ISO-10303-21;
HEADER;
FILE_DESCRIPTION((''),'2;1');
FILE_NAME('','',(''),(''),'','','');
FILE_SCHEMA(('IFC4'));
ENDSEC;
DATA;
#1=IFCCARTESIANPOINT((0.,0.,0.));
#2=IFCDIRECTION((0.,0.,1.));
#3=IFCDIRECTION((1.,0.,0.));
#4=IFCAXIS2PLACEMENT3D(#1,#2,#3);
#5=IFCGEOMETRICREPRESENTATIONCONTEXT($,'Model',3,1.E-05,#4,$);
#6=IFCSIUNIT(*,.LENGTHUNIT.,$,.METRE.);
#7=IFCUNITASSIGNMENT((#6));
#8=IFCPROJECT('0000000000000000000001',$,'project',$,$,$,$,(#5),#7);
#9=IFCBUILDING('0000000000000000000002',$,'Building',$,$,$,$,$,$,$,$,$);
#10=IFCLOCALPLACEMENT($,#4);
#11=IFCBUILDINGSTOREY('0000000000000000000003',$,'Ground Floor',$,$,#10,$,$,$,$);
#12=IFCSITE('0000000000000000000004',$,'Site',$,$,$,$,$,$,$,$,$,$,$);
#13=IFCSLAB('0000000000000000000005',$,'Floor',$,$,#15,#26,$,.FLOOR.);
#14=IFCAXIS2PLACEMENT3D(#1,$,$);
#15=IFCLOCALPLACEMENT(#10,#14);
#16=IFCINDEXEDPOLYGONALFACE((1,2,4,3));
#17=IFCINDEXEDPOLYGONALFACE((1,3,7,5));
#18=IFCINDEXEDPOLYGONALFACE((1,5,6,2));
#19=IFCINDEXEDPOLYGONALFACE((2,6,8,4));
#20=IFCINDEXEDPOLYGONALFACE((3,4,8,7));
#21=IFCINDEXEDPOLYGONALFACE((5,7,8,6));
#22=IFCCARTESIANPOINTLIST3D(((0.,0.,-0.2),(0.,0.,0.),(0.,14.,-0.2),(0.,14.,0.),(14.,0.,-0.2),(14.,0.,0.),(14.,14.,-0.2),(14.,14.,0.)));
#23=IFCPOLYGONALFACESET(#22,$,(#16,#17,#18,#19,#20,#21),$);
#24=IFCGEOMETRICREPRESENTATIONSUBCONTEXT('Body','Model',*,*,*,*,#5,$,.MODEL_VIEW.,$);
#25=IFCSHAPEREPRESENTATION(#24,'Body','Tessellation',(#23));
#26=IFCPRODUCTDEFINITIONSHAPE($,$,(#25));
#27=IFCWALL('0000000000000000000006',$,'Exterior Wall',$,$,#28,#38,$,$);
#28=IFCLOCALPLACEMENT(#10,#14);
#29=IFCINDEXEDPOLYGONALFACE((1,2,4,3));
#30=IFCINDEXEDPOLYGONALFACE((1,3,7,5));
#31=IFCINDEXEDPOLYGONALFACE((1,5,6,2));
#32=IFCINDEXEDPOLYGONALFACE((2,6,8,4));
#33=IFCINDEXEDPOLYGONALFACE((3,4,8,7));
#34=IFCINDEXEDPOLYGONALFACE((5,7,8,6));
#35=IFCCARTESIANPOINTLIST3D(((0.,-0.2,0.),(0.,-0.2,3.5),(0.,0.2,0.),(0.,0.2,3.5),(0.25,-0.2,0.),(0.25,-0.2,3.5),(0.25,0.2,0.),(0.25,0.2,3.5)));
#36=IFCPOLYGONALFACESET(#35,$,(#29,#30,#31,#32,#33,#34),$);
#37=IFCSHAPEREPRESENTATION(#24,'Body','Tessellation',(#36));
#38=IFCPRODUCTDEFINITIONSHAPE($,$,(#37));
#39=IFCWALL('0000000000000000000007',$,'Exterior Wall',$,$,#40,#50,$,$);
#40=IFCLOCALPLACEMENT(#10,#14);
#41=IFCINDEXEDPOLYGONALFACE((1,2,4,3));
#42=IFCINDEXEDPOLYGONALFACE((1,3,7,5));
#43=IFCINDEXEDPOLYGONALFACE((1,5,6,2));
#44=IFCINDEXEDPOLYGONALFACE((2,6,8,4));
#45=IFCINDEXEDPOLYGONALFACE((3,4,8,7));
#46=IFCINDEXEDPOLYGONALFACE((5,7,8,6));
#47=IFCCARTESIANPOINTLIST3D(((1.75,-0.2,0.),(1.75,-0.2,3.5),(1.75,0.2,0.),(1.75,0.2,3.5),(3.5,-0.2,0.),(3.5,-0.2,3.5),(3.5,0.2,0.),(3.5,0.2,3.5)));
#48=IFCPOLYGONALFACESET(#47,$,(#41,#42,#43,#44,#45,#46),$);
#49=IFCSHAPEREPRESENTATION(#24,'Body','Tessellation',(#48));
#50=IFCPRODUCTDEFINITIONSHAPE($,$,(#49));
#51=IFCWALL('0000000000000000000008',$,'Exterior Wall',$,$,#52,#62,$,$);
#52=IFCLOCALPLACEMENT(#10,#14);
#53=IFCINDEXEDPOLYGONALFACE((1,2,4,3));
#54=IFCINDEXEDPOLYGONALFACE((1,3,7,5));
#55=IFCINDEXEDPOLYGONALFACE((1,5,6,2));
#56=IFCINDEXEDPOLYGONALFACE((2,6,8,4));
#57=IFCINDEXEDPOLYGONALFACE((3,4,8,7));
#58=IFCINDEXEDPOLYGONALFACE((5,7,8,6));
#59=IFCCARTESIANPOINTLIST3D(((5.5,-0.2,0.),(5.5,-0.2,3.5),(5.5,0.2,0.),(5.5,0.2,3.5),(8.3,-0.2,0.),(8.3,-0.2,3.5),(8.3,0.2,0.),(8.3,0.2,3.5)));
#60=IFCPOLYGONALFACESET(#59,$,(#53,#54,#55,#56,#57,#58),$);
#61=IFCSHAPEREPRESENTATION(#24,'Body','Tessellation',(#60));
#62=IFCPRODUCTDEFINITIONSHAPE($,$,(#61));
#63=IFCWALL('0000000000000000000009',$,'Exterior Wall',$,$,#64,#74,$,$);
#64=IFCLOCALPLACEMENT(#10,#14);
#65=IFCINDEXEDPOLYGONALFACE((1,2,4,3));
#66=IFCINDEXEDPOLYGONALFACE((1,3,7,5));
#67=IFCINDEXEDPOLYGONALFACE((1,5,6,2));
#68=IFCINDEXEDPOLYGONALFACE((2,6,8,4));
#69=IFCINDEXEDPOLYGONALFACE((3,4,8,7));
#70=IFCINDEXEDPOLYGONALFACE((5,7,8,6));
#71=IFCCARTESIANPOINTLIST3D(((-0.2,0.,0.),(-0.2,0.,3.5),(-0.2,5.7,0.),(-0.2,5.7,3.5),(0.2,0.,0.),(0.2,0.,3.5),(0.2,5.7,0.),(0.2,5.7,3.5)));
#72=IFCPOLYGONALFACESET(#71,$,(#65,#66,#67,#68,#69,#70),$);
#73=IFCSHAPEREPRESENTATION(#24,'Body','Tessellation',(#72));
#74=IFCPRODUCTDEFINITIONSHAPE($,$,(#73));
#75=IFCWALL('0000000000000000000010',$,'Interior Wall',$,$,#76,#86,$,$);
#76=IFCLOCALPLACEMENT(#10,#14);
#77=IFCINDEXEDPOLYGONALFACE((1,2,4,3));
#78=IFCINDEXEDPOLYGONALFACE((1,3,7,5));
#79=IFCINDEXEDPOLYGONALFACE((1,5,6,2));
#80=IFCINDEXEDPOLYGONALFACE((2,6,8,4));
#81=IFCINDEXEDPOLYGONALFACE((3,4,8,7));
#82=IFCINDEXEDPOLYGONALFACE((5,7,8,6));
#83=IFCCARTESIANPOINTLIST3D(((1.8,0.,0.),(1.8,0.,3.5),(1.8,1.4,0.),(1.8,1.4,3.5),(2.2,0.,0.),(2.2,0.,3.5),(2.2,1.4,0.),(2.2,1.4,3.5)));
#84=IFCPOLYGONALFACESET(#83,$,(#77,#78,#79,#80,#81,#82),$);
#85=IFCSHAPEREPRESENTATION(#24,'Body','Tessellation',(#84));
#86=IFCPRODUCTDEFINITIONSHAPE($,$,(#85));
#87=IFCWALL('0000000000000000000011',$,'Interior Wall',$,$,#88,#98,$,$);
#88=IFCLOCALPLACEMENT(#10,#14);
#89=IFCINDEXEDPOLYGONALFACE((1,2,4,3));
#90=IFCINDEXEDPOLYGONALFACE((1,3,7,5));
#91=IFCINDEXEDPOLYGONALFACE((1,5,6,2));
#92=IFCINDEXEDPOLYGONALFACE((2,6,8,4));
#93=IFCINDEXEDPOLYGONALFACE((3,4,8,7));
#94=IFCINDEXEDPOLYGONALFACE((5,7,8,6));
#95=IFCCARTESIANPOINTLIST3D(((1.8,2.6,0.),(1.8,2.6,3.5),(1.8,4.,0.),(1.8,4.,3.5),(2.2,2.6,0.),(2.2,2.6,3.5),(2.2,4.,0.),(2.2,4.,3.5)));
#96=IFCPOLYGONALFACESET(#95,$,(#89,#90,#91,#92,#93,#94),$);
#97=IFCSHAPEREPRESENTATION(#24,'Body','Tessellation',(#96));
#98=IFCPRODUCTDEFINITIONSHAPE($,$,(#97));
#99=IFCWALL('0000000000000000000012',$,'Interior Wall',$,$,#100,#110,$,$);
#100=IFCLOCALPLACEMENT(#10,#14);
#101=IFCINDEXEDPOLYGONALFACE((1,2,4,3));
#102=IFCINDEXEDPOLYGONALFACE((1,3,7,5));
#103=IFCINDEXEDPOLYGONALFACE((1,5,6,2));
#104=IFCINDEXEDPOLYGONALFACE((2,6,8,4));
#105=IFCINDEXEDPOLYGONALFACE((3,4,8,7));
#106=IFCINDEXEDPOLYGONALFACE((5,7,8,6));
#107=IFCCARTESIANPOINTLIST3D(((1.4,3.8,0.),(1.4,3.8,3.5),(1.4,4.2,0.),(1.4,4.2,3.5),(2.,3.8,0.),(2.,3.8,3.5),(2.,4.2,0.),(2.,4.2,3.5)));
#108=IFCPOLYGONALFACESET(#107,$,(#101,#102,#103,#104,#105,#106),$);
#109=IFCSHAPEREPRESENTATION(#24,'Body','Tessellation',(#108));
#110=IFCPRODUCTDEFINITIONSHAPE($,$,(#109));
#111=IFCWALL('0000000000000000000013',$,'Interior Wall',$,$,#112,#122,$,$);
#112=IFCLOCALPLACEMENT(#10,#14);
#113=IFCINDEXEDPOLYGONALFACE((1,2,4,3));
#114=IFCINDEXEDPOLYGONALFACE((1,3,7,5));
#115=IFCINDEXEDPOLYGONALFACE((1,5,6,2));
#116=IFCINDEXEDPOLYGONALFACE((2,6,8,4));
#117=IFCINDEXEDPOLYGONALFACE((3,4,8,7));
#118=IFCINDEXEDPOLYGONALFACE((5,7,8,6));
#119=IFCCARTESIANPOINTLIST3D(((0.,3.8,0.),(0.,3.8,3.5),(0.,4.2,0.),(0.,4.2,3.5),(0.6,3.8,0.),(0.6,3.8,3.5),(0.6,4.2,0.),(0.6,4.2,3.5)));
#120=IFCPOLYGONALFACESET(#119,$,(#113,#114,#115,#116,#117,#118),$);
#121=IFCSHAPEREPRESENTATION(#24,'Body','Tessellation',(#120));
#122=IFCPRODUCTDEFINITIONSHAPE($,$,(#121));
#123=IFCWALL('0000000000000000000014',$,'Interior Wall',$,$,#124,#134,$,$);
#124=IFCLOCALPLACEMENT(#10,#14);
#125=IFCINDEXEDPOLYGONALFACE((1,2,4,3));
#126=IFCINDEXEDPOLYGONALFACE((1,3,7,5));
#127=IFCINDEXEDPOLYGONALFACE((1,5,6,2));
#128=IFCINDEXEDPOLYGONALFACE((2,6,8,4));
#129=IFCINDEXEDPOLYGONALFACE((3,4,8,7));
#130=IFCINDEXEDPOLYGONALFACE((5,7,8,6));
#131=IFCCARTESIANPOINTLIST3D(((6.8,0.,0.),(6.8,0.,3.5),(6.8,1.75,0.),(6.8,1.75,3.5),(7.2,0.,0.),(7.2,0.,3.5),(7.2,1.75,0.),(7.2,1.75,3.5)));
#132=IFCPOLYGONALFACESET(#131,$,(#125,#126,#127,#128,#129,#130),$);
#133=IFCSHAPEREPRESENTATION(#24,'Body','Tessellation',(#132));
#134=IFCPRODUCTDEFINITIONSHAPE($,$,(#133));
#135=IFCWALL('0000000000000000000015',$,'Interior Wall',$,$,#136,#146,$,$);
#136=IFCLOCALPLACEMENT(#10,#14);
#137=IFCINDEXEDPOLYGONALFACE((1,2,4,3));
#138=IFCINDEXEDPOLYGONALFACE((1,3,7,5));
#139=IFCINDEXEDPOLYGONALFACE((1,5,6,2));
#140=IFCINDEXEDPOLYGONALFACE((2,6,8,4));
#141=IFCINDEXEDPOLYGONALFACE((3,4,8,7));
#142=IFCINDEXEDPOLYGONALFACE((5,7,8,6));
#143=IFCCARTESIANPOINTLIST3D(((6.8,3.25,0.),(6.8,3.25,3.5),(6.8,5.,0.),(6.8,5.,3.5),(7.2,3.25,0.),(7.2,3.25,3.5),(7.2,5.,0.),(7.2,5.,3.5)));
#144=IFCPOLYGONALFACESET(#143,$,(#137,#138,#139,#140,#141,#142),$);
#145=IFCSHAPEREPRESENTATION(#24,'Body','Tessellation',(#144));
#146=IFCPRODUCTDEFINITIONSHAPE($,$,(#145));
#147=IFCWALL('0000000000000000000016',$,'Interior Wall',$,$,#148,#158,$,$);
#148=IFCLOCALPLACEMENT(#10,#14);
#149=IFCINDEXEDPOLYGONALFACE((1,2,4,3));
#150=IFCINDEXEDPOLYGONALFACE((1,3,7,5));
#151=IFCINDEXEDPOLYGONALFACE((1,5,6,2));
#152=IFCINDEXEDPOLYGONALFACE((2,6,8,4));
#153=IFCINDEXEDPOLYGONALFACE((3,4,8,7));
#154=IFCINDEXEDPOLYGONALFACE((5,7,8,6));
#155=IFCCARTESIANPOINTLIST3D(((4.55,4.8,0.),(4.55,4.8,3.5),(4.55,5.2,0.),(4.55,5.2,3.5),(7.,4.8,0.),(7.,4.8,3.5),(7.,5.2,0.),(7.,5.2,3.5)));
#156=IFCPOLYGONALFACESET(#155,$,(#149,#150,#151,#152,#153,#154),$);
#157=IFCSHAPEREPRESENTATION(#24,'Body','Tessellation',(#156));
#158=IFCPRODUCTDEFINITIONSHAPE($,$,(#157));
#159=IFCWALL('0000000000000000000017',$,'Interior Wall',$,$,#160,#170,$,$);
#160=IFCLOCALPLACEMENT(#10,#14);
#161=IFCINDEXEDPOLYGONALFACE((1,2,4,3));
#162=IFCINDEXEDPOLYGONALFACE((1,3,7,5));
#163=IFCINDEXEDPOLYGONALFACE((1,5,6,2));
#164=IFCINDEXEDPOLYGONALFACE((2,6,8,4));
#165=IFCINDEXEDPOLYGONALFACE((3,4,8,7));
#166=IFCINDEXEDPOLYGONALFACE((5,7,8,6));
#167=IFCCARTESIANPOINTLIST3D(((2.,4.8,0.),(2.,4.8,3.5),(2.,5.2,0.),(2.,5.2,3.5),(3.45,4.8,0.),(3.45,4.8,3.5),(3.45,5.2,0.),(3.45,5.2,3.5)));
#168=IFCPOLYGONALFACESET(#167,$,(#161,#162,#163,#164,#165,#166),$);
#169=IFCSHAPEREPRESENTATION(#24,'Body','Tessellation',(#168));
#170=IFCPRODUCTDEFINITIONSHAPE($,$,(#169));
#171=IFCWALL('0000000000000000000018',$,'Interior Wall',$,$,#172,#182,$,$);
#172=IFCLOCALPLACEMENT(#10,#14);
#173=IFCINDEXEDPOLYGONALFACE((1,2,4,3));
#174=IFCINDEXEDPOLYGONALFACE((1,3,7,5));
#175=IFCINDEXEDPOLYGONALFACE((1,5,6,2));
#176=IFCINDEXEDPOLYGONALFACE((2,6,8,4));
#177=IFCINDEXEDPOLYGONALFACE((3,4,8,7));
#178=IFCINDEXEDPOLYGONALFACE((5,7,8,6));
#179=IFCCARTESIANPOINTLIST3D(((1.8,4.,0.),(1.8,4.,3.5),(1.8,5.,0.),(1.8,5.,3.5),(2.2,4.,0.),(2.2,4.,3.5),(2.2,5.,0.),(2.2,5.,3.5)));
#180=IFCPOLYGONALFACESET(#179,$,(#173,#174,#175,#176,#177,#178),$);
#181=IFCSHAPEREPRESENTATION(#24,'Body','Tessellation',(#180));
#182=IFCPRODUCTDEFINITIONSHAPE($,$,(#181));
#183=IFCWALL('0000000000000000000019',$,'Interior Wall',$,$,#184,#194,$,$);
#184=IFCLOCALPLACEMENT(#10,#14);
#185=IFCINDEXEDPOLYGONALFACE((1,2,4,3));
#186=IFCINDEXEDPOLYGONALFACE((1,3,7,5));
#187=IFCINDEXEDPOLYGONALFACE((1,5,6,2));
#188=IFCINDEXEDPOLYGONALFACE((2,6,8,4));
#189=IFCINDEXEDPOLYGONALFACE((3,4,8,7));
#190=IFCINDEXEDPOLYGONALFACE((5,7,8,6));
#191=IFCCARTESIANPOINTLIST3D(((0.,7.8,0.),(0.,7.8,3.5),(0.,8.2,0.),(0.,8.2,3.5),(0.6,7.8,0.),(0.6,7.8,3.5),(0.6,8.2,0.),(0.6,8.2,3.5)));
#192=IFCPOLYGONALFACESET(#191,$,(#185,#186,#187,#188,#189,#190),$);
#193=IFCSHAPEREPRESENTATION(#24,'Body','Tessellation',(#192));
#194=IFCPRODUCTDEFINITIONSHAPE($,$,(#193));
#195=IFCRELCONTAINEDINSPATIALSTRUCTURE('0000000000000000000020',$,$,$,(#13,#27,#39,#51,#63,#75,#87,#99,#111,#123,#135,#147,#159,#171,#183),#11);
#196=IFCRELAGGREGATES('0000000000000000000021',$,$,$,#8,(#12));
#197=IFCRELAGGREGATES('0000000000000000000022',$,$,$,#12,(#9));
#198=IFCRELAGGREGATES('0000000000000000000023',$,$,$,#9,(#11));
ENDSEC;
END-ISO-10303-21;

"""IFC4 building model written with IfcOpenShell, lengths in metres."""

from ifc_helpers import new_model, si_unit, frame, origin_with_axes, place, context, subcontext, project, spatial, indexed_curve, outline, extrude, element, save


model = new_model("IFC4")

# Units and contexts
model_context = context("Model", 3, precision=1e-05, world=origin_with_axes())
body_context = subcontext(model_context, "Body", "Model", "MODEL_VIEW")
ifc_project = project(units=[si_unit("LENGTHUNIT", "METRE")], contexts=[model_context])

# Site, building, storey
site = spatial("IfcSite", under=ifc_project, Name="Site")
building = spatial("IfcBuilding", under=site, Name="Building")
storey_placement = place(None, origin_with_axes())
storey = spatial("IfcBuildingStorey", under=building, at=storey_placement, Name="Ground Floor")

# Slab
slab_placement = place(storey_placement, frame((0.0, 0.0, -0.2), z_axis=(0.0, 0.0, 1.0), x_axis=(1.0, 0.0, 0.0)))
element("IfcSlab", 1, at=slab_placement, inside=storey, Name="Floor", PredefinedType="FLOOR", context=body_context, shape_type="SweptSolid", body=[
    extrude(outline(indexed_curve([(0.0, 0.0), (14.0, 0.0), (14.0, 14.0), (0.0, 14.0)])), None, (0.0, 0.0, 1.0), 0.2),
])

# Walls
wall_1_placement = place(storey_placement, origin_with_axes())
element("IfcWall", 2, at=wall_1_placement, inside=storey, Name="Exterior Wall", context=body_context, shape_type="SweptSolid", body=[
    extrude(outline(indexed_curve([(0.0, 0.0), (0.0, 0.4), (0.25, 0.4), (0.25, 0.0), (0.0, 0.0)], self_intersect=False)), frame((0.0, -0.2, 0.0), z_axis=(0.0, 0.0, 1.0), x_axis=(1.0, 0.0, 0.0)), (0.0, 0.0, 1.0), 3.5),
])
wall_2_placement = place(storey_placement, frame((1.75, 0.0, 0.0), z_axis=(0.0, 0.0, 1.0), x_axis=(1.0, 0.0, 0.0)))
element("IfcWall", 3, at=wall_2_placement, inside=storey, Name="Exterior Wall", context=body_context, shape_type="SweptSolid", body=[
    extrude(outline(indexed_curve([(0.0, 0.0), (0.0, 0.4), (1.75, 0.4), (1.75, 0.0), (0.0, 0.0)], self_intersect=False)), frame((0.0, -0.2, 0.0), z_axis=(0.0, 0.0, 1.0), x_axis=(1.0, 0.0, 0.0)), (0.0, 0.0, 1.0), 3.5),
])
wall_3_placement = place(storey_placement, frame((5.5, 0.0, 0.0), z_axis=(0.0, 0.0, 1.0), x_axis=(1.0, 0.0, 0.0)))
element("IfcWall", 4, at=wall_3_placement, inside=storey, Name="Exterior Wall", context=body_context, shape_type="SweptSolid", body=[
    extrude(outline(indexed_curve([(0.0, 0.0), (0.0, 0.4), (2.8, 0.4), (2.8, 0.0), (0.0, 0.0)], self_intersect=False)), frame((0.0, -0.2, 0.0), z_axis=(0.0, 0.0, 1.0), x_axis=(1.0, 0.0, 0.0)), (0.0, 0.0, 1.0), 3.5),
])
wall_4_placement = place(storey_placement, frame((0.0, 5.7, 0.0), z_axis=(0.0, 0.0, 1.0), x_axis=(0.0, -1.0, 0.0)))
element("IfcWall", 5, at=wall_4_placement, inside=storey, Name="Exterior Wall", context=body_context, shape_type="SweptSolid", body=[
    extrude(outline(indexed_curve([(0.0, 0.0), (0.0, 0.4), (5.7, 0.4), (5.7, 0.0), (0.0, 0.0)], self_intersect=False)), frame((0.0, -0.2, 0.0), z_axis=(0.0, 0.0, 1.0), x_axis=(1.0, 0.0, 0.0)), (0.0, 0.0, 1.0), 3.5),
])
for number, where, z_axis, x_axis, name in (
    (6, (2.0, 0.0, 0.0), (0.0, 0.0, 1.0), (0.0, 1.0, 0.0), "Interior Wall"),
    (7, (2.0, 2.6, 0.0), (0.0, 0.0, 1.0), (0.0, 1.0, 0.0), "Interior Wall"),
):
    element("IfcWall", number, at=place(storey_placement, frame(where, z_axis=z_axis, x_axis=x_axis)), inside=storey, Name=name, context=body_context, shape_type="SweptSolid", body=[
        extrude(outline(indexed_curve([(0.0, 0.0), (0.0, 0.4), (1.4, 0.4), (1.4, 0.0), (0.0, 0.0)], self_intersect=False)), frame((0.0, -0.2, 0.0), z_axis=(0.0, 0.0, 1.0), x_axis=(1.0, 0.0, 0.0)), (0.0, 0.0, 1.0), 3.5),
    ])
for number, where, z_axis, x_axis, name in (
    (8, (2.0, 4.0, 0.0), (0.0, 0.0, 1.0), (-1.0, 0.0, 0.0), "Interior Wall"),
    (9, (0.6, 4.0, 0.0), (0.0, 0.0, 1.0), (-1.0, 0.0, 0.0), "Interior Wall"),
):
    element("IfcWall", number, at=place(storey_placement, frame(where, z_axis=z_axis, x_axis=x_axis)), inside=storey, Name=name, context=body_context, shape_type="SweptSolid", body=[
        extrude(outline(indexed_curve([(0.0, 0.0), (0.0, 0.4), (0.6, 0.4), (0.6, 0.0), (0.0, 0.0)], self_intersect=False)), frame((0.0, -0.2, 0.0), z_axis=(0.0, 0.0, 1.0), x_axis=(1.0, 0.0, 0.0)), (0.0, 0.0, 1.0), 3.5),
    ])
for number, where, z_axis, x_axis, name in (
    (10, (7.0, 0.0, 0.0), (0.0, 0.0, 1.0), (0.0, 1.0, 0.0), "Interior Wall"),
    (11, (7.0, 3.25, 0.0), (0.0, 0.0, 1.0), (0.0, 1.0, 0.0), "Interior Wall"),
):
    element("IfcWall", number, at=place(storey_placement, frame(where, z_axis=z_axis, x_axis=x_axis)), inside=storey, Name=name, context=body_context, shape_type="SweptSolid", body=[
        extrude(outline(indexed_curve([(0.0, 0.0), (0.0, 0.4), (1.75, 0.4), (1.75, 0.0), (0.0, 0.0)], self_intersect=False)), frame((0.0, -0.2, 0.0), z_axis=(0.0, 0.0, 1.0), x_axis=(1.0, 0.0, 0.0)), (0.0, 0.0, 1.0), 3.5),
    ])
wall_5_placement = place(storey_placement, frame((7.0, 5.0, 0.0), z_axis=(0.0, 0.0, 1.0), x_axis=(-1.0, 0.0, 0.0)))
element("IfcWall", 12, at=wall_5_placement, inside=storey, Name="Interior Wall", context=body_context, shape_type="SweptSolid", body=[
    extrude(outline(indexed_curve([(0.0, 0.0), (0.0, 0.4), (2.45, 0.4), (2.45, 0.0), (0.0, 0.0)], self_intersect=False)), frame((0.0, -0.2, 0.0), z_axis=(0.0, 0.0, 1.0), x_axis=(1.0, 0.0, 0.0)), (0.0, 0.0, 1.0), 3.5),
])
wall_6_placement = place(storey_placement, frame((3.45, 5.0, 0.0), z_axis=(0.0, 0.0, 1.0), x_axis=(-1.0, 0.0, 0.0)))
element("IfcWall", 13, at=wall_6_placement, inside=storey, Name="Interior Wall", context=body_context, shape_type="SweptSolid", body=[
    extrude(outline(indexed_curve([(0.0, 0.0), (0.0, 0.4), (1.45, 0.4), (1.45, 0.0), (0.0, 0.0)], self_intersect=False)), frame((0.0, -0.2, 0.0), z_axis=(0.0, 0.0, 1.0), x_axis=(1.0, 0.0, 0.0)), (0.0, 0.0, 1.0), 3.5),
])
wall_7_placement = place(storey_placement, frame((2.0, 5.0, 0.0), z_axis=(0.0, 0.0, 1.0), x_axis=(0.0, -1.0, 0.0)))
element("IfcWall", 14, at=wall_7_placement, inside=storey, Name="Interior Wall", context=body_context, shape_type="SweptSolid", body=[
    extrude(outline(indexed_curve([(0.0, 0.0), (0.0, 0.4), (1.0, 0.4), (1.0, 0.0), (0.0, 0.0)], self_intersect=False)), frame((0.0, -0.2, 0.0), z_axis=(0.0, 0.0, 1.0), x_axis=(1.0, 0.0, 0.0)), (0.0, 0.0, 1.0), 3.5),
])
wall_8_placement = place(storey_placement, frame((0.6, 8.0, 0.0), z_axis=(0.0, 0.0, 1.0), x_axis=(-1.0, 0.0, 0.0)))
element("IfcWall", 15, at=wall_8_placement, inside=storey, Name="Interior Wall", context=body_context, shape_type="SweptSolid", body=[
    extrude(outline(indexed_curve([(0.0, 0.0), (0.0, 0.4), (0.6, 0.4), (0.6, 0.0), (0.0, 0.0)], self_intersect=False)), frame((0.0, -0.2, 0.0), z_axis=(0.0, 0.0, 1.0), x_axis=(1.0, 0.0, 0.0)), (0.0, 0.0, 1.0), 3.5),
])

save(model, "model.ifc")
